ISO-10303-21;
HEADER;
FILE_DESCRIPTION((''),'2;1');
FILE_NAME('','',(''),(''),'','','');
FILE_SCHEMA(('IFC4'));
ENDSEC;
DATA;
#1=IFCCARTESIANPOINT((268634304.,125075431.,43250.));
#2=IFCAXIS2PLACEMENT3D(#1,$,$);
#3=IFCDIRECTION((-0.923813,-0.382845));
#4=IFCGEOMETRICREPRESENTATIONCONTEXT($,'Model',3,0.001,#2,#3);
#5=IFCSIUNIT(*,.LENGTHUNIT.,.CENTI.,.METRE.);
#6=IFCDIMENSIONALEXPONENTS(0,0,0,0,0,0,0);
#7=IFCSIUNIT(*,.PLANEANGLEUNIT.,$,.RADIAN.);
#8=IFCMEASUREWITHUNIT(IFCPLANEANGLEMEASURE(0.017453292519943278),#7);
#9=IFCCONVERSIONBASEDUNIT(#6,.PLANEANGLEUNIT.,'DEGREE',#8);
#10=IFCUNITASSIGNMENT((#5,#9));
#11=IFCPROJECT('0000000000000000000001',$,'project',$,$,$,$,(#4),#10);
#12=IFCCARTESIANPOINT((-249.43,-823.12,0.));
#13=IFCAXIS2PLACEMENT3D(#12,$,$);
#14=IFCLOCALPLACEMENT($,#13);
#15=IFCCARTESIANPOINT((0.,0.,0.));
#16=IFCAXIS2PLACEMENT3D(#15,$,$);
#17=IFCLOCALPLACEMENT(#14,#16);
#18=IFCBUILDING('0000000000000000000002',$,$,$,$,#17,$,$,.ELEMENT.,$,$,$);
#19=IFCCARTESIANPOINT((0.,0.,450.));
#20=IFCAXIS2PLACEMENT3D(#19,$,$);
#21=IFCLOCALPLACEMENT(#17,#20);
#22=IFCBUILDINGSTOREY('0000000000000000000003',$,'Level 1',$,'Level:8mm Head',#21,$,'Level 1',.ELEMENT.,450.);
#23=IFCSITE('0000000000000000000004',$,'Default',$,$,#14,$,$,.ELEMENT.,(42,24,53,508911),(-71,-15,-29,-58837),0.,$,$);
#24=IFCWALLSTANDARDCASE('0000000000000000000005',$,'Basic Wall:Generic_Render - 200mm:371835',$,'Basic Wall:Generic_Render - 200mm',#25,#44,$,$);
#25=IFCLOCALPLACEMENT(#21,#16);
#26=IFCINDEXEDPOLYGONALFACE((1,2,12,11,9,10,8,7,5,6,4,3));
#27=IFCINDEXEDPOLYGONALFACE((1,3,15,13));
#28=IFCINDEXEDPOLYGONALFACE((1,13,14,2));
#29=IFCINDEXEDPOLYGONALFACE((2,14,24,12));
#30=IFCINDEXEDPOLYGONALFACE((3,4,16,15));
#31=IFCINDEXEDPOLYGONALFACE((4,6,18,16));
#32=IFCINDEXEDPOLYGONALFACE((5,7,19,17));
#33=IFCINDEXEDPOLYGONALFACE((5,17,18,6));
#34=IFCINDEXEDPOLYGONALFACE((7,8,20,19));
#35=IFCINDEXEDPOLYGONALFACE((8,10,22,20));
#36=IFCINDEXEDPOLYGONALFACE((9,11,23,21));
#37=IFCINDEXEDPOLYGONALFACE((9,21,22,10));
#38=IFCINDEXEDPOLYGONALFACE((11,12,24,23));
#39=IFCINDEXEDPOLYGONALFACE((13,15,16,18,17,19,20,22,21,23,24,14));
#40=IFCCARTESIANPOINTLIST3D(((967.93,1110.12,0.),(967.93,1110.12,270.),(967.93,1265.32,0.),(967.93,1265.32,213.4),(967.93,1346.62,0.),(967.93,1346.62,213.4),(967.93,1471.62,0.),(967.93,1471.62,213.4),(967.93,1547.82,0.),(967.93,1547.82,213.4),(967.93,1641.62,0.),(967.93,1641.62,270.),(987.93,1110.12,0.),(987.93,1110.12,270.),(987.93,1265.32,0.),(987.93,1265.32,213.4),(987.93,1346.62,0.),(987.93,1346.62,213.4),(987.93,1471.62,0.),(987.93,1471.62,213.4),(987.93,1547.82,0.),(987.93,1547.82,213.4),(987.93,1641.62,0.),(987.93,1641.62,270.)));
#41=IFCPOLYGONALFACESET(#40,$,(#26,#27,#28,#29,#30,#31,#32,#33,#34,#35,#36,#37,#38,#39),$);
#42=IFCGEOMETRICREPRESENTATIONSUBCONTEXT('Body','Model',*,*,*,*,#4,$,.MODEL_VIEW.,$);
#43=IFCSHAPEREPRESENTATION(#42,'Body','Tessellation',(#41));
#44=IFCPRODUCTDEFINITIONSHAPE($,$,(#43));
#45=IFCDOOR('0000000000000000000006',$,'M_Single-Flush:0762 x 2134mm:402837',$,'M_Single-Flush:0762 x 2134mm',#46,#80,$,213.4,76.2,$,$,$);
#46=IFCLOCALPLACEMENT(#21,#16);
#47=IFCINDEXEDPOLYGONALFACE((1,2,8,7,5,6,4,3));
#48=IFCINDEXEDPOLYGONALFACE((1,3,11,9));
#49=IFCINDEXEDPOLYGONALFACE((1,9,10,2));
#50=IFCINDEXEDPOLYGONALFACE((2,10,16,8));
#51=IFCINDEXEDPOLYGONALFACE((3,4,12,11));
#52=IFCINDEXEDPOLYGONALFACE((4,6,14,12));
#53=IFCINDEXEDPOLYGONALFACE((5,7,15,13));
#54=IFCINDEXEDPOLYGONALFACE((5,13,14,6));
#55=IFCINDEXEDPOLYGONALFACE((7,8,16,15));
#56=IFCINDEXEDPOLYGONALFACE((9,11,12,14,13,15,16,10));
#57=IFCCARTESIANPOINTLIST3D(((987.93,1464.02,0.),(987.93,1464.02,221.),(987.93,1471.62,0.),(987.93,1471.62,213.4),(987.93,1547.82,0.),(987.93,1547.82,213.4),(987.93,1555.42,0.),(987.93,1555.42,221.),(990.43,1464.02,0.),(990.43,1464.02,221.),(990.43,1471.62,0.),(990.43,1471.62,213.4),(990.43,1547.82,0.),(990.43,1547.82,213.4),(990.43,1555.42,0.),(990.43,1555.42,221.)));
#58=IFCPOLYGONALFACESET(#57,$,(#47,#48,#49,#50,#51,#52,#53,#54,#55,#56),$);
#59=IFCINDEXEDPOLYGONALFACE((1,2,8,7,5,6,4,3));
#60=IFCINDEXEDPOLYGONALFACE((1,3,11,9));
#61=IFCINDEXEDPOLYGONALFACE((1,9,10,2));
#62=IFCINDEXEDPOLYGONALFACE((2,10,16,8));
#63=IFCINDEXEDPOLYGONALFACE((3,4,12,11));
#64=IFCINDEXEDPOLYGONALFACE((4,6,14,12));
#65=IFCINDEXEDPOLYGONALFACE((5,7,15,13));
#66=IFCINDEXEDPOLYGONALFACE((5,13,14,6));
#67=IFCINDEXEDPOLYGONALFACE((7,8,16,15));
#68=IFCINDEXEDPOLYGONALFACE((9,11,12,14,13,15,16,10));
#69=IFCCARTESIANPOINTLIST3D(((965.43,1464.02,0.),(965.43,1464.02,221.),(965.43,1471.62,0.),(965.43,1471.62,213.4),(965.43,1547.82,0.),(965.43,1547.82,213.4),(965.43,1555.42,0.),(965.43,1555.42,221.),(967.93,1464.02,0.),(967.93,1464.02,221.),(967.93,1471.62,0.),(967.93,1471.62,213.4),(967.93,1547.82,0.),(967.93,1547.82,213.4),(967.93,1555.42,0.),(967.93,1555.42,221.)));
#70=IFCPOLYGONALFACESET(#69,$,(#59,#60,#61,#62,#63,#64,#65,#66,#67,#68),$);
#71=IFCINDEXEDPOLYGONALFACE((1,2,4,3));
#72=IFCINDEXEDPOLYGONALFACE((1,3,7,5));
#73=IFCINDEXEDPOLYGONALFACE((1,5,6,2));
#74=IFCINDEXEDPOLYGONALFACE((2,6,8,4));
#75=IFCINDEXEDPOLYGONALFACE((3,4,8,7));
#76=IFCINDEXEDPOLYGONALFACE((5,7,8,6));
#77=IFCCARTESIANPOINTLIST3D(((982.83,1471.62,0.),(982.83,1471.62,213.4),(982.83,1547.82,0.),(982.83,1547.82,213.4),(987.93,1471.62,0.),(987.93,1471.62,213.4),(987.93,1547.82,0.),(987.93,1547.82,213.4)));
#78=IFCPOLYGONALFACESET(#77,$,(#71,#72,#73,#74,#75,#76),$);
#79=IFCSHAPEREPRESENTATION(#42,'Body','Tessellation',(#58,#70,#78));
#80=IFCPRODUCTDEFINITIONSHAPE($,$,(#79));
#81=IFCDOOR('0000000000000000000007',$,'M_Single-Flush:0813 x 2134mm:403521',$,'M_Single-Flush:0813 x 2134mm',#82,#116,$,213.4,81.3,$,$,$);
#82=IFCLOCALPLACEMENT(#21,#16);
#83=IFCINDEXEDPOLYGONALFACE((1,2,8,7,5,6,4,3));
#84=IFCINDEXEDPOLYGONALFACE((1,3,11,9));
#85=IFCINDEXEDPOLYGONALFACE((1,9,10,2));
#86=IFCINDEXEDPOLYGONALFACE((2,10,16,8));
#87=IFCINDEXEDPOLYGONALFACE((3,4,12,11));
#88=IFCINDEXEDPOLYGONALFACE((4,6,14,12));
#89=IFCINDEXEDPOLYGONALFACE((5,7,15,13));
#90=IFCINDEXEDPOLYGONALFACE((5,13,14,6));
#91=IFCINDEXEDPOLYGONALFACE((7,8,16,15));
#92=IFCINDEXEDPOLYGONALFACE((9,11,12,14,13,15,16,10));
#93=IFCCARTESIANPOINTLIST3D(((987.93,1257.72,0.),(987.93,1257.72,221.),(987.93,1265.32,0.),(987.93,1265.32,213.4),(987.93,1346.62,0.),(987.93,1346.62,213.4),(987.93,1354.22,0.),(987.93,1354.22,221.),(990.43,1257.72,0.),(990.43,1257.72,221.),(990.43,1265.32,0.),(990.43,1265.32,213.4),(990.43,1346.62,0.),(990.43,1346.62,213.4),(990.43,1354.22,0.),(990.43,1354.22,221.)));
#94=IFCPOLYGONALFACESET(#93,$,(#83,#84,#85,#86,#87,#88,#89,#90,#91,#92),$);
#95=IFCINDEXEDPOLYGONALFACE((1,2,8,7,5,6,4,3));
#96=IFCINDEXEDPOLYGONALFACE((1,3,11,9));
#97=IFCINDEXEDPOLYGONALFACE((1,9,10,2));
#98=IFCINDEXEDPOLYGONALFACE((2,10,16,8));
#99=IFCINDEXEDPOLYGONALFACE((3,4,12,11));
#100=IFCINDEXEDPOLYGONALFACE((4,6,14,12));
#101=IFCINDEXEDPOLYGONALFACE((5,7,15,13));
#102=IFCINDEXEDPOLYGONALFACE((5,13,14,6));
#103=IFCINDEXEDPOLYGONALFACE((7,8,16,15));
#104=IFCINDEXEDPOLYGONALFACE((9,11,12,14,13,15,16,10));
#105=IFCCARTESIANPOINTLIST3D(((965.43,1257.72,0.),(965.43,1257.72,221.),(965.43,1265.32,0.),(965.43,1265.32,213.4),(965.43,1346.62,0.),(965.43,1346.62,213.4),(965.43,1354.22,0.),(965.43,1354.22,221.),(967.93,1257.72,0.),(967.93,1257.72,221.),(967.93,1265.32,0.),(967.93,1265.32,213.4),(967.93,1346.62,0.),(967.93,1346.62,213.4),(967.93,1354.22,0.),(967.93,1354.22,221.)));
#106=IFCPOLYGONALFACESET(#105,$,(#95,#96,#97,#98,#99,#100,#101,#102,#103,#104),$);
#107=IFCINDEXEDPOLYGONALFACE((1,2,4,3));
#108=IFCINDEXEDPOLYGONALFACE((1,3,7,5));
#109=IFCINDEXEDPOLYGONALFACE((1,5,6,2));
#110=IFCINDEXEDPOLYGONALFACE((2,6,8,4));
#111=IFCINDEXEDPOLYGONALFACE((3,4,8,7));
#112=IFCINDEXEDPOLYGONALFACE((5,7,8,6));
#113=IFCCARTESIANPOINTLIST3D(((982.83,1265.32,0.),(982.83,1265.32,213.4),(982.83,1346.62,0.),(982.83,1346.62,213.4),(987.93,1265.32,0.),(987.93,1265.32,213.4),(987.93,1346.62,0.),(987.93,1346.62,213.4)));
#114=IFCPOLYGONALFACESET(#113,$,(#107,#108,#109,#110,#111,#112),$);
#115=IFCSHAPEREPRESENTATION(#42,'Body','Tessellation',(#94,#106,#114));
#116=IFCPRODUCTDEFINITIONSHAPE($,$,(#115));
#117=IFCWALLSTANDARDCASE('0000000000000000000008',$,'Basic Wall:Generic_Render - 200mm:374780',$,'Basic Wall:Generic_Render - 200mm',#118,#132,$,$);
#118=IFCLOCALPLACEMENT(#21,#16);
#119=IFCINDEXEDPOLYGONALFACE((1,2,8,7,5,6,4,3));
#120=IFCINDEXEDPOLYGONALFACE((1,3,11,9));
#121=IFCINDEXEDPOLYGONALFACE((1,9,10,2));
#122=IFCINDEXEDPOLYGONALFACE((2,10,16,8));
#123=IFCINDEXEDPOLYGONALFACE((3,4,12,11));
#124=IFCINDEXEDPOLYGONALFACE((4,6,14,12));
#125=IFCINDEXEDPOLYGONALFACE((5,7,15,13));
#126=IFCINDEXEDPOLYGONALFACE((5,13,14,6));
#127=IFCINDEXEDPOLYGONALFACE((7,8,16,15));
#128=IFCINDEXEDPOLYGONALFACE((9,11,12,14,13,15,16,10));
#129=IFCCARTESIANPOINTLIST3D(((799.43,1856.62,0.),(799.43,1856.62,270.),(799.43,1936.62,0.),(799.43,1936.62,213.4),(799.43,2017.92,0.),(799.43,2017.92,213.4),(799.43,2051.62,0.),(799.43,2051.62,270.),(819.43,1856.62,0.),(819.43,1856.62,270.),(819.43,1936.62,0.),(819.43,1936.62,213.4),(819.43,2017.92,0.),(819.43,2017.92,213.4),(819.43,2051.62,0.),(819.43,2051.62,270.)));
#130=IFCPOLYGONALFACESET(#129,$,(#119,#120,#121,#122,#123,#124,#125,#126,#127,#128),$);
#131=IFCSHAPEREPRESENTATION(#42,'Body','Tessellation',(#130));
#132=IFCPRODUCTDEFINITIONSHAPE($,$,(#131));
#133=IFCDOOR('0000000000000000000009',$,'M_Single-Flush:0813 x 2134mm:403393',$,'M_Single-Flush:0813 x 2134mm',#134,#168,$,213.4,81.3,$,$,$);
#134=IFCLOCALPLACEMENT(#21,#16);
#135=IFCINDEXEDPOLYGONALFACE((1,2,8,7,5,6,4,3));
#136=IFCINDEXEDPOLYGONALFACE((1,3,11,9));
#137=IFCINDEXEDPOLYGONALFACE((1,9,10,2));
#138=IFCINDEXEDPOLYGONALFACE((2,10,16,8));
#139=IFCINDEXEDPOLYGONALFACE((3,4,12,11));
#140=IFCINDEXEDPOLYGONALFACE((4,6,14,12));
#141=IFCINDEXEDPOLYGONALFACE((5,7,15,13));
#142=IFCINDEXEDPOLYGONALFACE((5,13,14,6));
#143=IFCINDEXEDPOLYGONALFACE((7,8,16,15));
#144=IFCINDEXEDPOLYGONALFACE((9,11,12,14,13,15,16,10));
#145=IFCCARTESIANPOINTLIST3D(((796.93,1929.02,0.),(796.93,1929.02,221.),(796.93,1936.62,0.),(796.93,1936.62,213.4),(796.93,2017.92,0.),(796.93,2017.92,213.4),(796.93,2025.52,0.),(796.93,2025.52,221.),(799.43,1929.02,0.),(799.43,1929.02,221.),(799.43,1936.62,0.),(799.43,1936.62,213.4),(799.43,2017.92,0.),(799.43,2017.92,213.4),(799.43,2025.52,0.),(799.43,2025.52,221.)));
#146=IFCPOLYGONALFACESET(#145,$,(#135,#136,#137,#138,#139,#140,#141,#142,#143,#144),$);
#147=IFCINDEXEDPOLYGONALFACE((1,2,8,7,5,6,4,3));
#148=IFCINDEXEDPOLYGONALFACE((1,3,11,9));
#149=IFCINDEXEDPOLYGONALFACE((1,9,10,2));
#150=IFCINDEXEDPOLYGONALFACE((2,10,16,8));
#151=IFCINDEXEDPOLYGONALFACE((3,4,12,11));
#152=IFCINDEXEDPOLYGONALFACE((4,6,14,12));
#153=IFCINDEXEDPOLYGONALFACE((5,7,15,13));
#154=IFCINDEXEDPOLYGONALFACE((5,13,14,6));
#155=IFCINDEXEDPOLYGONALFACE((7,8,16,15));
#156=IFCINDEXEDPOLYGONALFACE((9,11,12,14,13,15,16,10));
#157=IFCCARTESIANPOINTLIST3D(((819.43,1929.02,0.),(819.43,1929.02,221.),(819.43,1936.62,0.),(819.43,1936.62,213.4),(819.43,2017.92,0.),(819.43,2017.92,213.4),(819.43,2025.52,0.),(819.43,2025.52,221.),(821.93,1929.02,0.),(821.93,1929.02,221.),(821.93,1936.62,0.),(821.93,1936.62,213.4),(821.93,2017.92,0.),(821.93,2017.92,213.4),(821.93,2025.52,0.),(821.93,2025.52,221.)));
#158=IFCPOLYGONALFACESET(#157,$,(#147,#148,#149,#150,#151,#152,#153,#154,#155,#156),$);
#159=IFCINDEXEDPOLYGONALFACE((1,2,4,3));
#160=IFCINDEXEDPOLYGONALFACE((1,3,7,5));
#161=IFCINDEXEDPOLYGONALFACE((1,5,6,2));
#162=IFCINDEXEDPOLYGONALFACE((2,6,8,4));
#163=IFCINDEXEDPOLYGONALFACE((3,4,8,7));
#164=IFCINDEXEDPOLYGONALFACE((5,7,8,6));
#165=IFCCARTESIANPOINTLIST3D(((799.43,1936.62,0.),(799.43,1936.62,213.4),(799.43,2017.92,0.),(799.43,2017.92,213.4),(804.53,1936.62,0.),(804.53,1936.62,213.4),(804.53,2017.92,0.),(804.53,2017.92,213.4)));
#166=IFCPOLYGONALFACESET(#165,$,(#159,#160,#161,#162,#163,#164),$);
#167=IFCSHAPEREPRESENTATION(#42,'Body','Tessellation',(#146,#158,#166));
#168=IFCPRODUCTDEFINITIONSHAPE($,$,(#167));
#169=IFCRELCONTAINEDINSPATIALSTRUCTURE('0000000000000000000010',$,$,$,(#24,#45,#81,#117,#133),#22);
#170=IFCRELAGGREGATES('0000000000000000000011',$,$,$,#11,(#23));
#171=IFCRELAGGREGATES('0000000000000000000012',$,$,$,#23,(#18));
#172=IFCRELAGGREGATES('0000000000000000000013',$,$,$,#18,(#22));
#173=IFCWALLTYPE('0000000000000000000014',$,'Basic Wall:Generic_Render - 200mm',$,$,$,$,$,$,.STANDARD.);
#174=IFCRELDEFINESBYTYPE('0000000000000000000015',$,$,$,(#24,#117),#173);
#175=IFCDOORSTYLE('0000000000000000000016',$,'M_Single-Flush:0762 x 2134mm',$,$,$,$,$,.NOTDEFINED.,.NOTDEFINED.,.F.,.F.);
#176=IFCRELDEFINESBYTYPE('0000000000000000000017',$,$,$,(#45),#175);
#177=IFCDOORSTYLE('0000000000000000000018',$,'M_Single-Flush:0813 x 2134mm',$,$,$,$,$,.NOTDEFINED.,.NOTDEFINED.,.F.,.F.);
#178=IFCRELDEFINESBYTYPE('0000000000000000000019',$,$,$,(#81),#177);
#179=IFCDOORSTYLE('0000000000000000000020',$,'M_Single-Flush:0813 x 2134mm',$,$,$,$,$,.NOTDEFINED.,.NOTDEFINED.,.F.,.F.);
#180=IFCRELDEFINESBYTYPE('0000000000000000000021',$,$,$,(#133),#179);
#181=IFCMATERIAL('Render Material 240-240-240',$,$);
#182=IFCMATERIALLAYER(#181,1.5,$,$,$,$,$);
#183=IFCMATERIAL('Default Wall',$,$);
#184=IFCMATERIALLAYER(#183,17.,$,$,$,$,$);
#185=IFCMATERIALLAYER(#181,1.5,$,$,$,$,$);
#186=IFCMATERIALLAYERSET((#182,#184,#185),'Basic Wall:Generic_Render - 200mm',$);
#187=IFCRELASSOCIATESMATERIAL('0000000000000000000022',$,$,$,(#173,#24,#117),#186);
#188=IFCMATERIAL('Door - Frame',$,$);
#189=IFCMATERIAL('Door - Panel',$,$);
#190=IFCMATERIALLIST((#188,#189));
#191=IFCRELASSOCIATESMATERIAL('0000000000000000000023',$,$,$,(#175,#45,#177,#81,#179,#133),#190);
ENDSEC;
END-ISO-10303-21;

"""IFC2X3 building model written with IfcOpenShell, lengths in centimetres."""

from ifc_helpers import new_model, entity, si_unit, converted_unit, direction, frame, frame_2d, origin, place, context, subcontext, project, spatial, polyline, rectangle, outline, extrude, source, transform, mapped, material, material_list, layer, layer_set, layer_usage, type_object, type_shapes, element, fill, save


model = new_model("IFC2X3")

# Units and contexts
model_context = context("Model", 3, precision=0.001, world=frame((268634304.0, 125075431.0, 43250.0)), true_north=direction((-0.923813, -0.382845)))
body_context = subcontext(model_context, "Body", "Model", "MODEL_VIEW")
ifc_project = project(units=[si_unit("LENGTHUNIT", "METRE", prefix="CENTI"), converted_unit("PLANEANGLEUNIT", "DEGREE", entity("IfcPlaneAngleMeasure", 0.017453292519943278), si_unit("PLANEANGLEUNIT", "RADIAN"), dimensions=[0, 0, 0, 0, 0, 0, 0])], contexts=[model_context])

# Site, building, storey
site_placement = place(None, frame((-249.43, -823.12, 0.0)))
site = spatial("IfcSite", under=ifc_project, at=site_placement, Name="Default", CompositionType="ELEMENT", RefLatitude=(42, 24, 53, 508911), RefLongitude=(-71, -15, -29, -58837), RefElevation=0.0)
building_placement = place(site_placement, origin())
building = spatial("IfcBuilding", under=site, at=building_placement, CompositionType="ELEMENT")
storey_placement = place(building_placement, frame((0.0, 0.0, 450.0)))
storey = spatial("IfcBuildingStorey", under=building, at=storey_placement, Name="Level 1", ObjectType="Level:8mm Head", LongName="Level 1", CompositionType="ELEMENT", Elevation=450.0)

# Shared definitions
ifc_material_1 = material(Name="Render Material 240-240-240")

# Shared definitions
ifc_layer_1 = layer(ifc_material_1, 1.5)
ifc_material_2 = material(Name="Default Wall")
ifc_layer_2 = layer(ifc_material_2, 17.0)
ifc_layer_3 = layer(ifc_material_1, 1.5)
ifc_layer_set_1 = layer_set([ifc_layer_1, ifc_layer_2, ifc_layer_3], Name="Basic Wall:Generic_Render - 200mm")
wall_type_1 = type_object("IfcWallType", Name="Basic Wall:Generic_Render - 200mm", PredefinedType="STANDARD", material=ifc_layer_set_1)
ifc_material_3 = material(Name="Door - Frame")
ifc_material_4 = material(Name="Door - Panel")
ifc_material_list_1 = material_list([ifc_material_3, ifc_material_4])

# Wall, openings, doors
ifc_layer_usage_1 = layer_usage(ifc_layer_set_1, "AXIS2", "NEGATIVE", 10.0)
wall_1_placement = place(storey_placement, frame((977.93, 1641.62, 0.0), z_axis=(0.0, 0.0, 1.0), x_axis=(0.0, -1.0, 0.0)))
wall_1 = element("IfcWallStandardCase", 1, at=wall_1_placement, inside=storey, type_object=wall_type_1, material=ifc_layer_usage_1, Name="Basic Wall:Generic_Render - 200mm:371835", ObjectType="Basic Wall:Generic_Render - 200mm", context=body_context, shape_type="SweptSolid", body=[
    extrude(rectangle(XDim=531.5, YDim=20.0, at=frame_2d((265.75, 0.0), x_axis=(1.0, 0.0))), origin(), (0.0, 0.0, 1.0), 270.0),
])
opening_1_placement = place(wall_1_placement, frame((93.8, -10.0, 0.0)))
opening_1 = element("IfcOpeningElement", 2, at=opening_1_placement, cuts=wall_1, ObjectType="Opening", context=body_context, shape_type="SweptSolid", body=[
    extrude(rectangle(XDim=76.2, YDim=213.4, at=frame_2d((106.7, 38.1), x_axis=(0.0, 1.0))), frame((0.0, 0.0, 0.0), z_axis=(0.0, 1.0, 0.0), x_axis=(0.0, 0.0, 1.0)), (0.0, 0.0, 1.0), 20.0),
])
opening_2_placement = place(wall_1_placement, frame((295.0, -10.0, 0.0)))
opening_2 = element("IfcOpeningElement", 3, at=opening_2_placement, cuts=wall_1, ObjectType="Opening", context=body_context, shape_type="SweptSolid", body=[
    extrude(rectangle(XDim=81.3, YDim=213.4, at=frame_2d((106.7, 40.65), x_axis=(0.0, -1.0))), frame((0.0, 0.0, 0.0), z_axis=(0.0, 1.0, 0.0), x_axis=(0.0, 0.0, 1.0)), (0.0, 0.0, 1.0), 20.0),
])
door_style_1 = type_object("IfcDoorStyle", Name="M_Single-Flush:0762 x 2134mm", ConstructionType="NOTDEFINED", OperationType="NOTDEFINED", ParameterTakesPrecedence=False, Sizeable=False, material=ifc_material_list_1)
shared_shape_1 = source(origin(), body_context, "Body", "SweptSolid", [
    extrude(outline(polyline([(-45.7, -112.4), (45.7, -112.4), (45.7, 108.6), (38.1, 108.6), (38.1, -104.8), (-38.1, -104.8), (-38.1, 108.6), (-45.7, 108.6), (-45.7, -112.4)])), frame((38.1, 20.0, 108.6), z_axis=(0.0, 1.0, 0.0), x_axis=(1.0, 0.0, 0.0)), (0.0, 0.0, 1.0), 2.5),
    extrude(outline(polyline([(-112.4, -45.7), (108.6, -45.7), (108.6, -38.1), (-104.8, -38.1), (-104.8, 38.1), (108.6, 38.1), (108.6, 45.7), (-112.4, 45.7), (-112.4, -45.7)])), frame((38.1, -2.5, 108.6), z_axis=(0.0, 1.0, 0.0), x_axis=(0.0, 0.0, -1.0)), (0.0, 0.0, 1.0), 2.5),
    extrude(rectangle(XDim=5.1, YDim=76.2, at=frame_2d((0.0, 0.0), x_axis=(1.0, 0.0))), frame((38.1, 17.45, 0.0), z_axis=(0.0, 0.0, 1.0), x_axis=(0.0, 1.0, 0.0)), (0.0, 0.0, 1.0), 213.4),
])
type_shapes(door_style_1, [shared_shape_1])
door_1_placement = place(opening_1_placement, origin())
door_1 = element("IfcDoor", 4, at=door_1_placement, inside=storey, type_object=door_style_1, material=ifc_material_list_1, Name="M_Single-Flush:0762 x 2134mm:402837", ObjectType="M_Single-Flush:0762 x 2134mm", OverallHeight=213.4, OverallWidth=76.2, context=body_context, shape_type="MappedRepresentation", body=[
    mapped(shared_shape_1, transform((0.0, 0.0, 0.0), scale=1.0)),
])
fill(opening_1, door_1)
door_style_2 = type_object("IfcDoorStyle", Name="M_Single-Flush:0813 x 2134mm", ConstructionType="NOTDEFINED", OperationType="NOTDEFINED", ParameterTakesPrecedence=False, Sizeable=False, material=ifc_material_list_1)
shared_shape_2 = source(origin(), body_context, "Body", "SweptSolid", [
    extrude(outline(polyline([(-48.25, -112.4), (48.25, -112.4), (48.25, 108.6), (40.65, 108.6), (40.65, -104.8), (-40.65, -104.8), (-40.65, 108.6), (-48.25, 108.6), (-48.25, -112.4)])), frame((40.65, 22.5, 108.6), z_axis=(0.0, -1.0, 0.0), x_axis=(-1.0, 0.0, 0.0)), (0.0, 0.0, 1.0), 2.5),
    extrude(outline(polyline([(-112.4, -48.25), (108.6, -48.25), (108.6, -40.65), (-104.8, -40.65), (-104.8, 40.65), (108.6, 40.65), (108.6, 48.25), (-112.4, 48.25), (-112.4, -48.25)])), frame((40.65, 0.0, 108.6), z_axis=(0.0, -1.0, 0.0), x_axis=(0.0, 0.0, -1.0)), (0.0, 0.0, 1.0), 2.5),
    extrude(rectangle(XDim=81.3, YDim=5.1, at=frame_2d((0.0, 0.0), x_axis=(1.0, 0.0))), frame((40.65, 17.45, 0.0)), (0.0, 0.0, 1.0), 213.4),
])
type_shapes(door_style_2, [shared_shape_2])
door_2_placement = place(opening_2_placement, origin())
door_2 = element("IfcDoor", 5, at=door_2_placement, inside=storey, type_object=door_style_2, material=ifc_material_list_1, Name="M_Single-Flush:0813 x 2134mm:403521", ObjectType="M_Single-Flush:0813 x 2134mm", OverallHeight=213.4, OverallWidth=81.3, context=body_context, shape_type="MappedRepresentation", body=[
    mapped(shared_shape_2, transform((0.0, 0.0, 0.0), scale=1.0)),
])
fill(opening_2, door_2)

# Wall, opening, door
ifc_layer_usage_2 = layer_usage(ifc_layer_set_1, "AXIS2", "NEGATIVE", 10.0)
wall_2_placement = place(storey_placement, frame((809.43, 1856.62, 0.0), z_axis=(0.0, 0.0, 1.0), x_axis=(0.0, 1.0, 0.0)))
wall_2 = element("IfcWallStandardCase", 6, at=wall_2_placement, inside=storey, type_object=wall_type_1, material=ifc_layer_usage_2, Name="Basic Wall:Generic_Render - 200mm:374780", ObjectType="Basic Wall:Generic_Render - 200mm", context=body_context, shape_type="SweptSolid", body=[
    extrude(rectangle(XDim=195.0, YDim=20.0, at=frame_2d((97.5, 0.0), x_axis=(-1.0, 0.0))), origin(), (0.0, 0.0, 1.0), 270.0),
])
opening_3_placement = place(wall_2_placement, frame((80.0, -10.0, 0.0)))
opening_3 = element("IfcOpeningElement", 7, at=opening_3_placement, cuts=wall_2, ObjectType="Opening", context=body_context, shape_type="SweptSolid", body=[
    extrude(rectangle(XDim=81.3, YDim=213.4, at=frame_2d((106.7, 40.65), x_axis=(0.0, 1.0))), frame((0.0, 0.0, 0.0), z_axis=(0.0, 1.0, 0.0), x_axis=(0.0, 0.0, 1.0)), (0.0, 0.0, 1.0), 20.0),
])
door_style_3 = type_object("IfcDoorStyle", Name="M_Single-Flush:0813 x 2134mm", ConstructionType="NOTDEFINED", OperationType="NOTDEFINED", ParameterTakesPrecedence=False, Sizeable=False, material=ifc_material_list_1)
shared_shape_3 = source(origin(), body_context, "Body", "SweptSolid", [
    extrude(outline(polyline([(-48.25, -112.4), (48.25, -112.4), (48.25, 108.6), (40.65, 108.6), (40.65, -104.8), (-40.65, -104.8), (-40.65, 108.6), (-48.25, 108.6), (-48.25, -112.4)])), frame((40.65, 20.0, 108.6), z_axis=(0.0, 1.0, 0.0), x_axis=(1.0, 0.0, 0.0)), (0.0, 0.0, 1.0), 2.5),
    extrude(outline(polyline([(-112.4, -48.25), (108.6, -48.25), (108.6, -40.65), (-104.8, -40.65), (-104.8, 40.65), (108.6, 40.65), (108.6, 48.25), (-112.4, 48.25), (-112.4, -48.25)])), frame((40.65, -2.5, 108.6), z_axis=(0.0, 1.0, 0.0), x_axis=(0.0, 0.0, -1.0)), (0.0, 0.0, 1.0), 2.5),
    extrude(rectangle(XDim=5.1, YDim=81.3, at=frame_2d((0.0, 0.0), x_axis=(1.0, 0.0))), frame((40.65, 17.45, 0.0), z_axis=(0.0, 0.0, 1.0), x_axis=(0.0, 1.0, 0.0)), (0.0, 0.0, 1.0), 213.4),
])
type_shapes(door_style_3, [shared_shape_3])
door_3_placement = place(opening_3_placement, origin())
door_3 = element("IfcDoor", 8, at=door_3_placement, inside=storey, type_object=door_style_3, material=ifc_material_list_1, Name="M_Single-Flush:0813 x 2134mm:403393", ObjectType="M_Single-Flush:0813 x 2134mm", OverallHeight=213.4, OverallWidth=81.3, context=body_context, shape_type="MappedRepresentation", body=[
    mapped(shared_shape_3, transform((0.0, 0.0, 0.0), scale=1.0)),
])
fill(opening_3, door_3)

save(model, "model.ifc")
